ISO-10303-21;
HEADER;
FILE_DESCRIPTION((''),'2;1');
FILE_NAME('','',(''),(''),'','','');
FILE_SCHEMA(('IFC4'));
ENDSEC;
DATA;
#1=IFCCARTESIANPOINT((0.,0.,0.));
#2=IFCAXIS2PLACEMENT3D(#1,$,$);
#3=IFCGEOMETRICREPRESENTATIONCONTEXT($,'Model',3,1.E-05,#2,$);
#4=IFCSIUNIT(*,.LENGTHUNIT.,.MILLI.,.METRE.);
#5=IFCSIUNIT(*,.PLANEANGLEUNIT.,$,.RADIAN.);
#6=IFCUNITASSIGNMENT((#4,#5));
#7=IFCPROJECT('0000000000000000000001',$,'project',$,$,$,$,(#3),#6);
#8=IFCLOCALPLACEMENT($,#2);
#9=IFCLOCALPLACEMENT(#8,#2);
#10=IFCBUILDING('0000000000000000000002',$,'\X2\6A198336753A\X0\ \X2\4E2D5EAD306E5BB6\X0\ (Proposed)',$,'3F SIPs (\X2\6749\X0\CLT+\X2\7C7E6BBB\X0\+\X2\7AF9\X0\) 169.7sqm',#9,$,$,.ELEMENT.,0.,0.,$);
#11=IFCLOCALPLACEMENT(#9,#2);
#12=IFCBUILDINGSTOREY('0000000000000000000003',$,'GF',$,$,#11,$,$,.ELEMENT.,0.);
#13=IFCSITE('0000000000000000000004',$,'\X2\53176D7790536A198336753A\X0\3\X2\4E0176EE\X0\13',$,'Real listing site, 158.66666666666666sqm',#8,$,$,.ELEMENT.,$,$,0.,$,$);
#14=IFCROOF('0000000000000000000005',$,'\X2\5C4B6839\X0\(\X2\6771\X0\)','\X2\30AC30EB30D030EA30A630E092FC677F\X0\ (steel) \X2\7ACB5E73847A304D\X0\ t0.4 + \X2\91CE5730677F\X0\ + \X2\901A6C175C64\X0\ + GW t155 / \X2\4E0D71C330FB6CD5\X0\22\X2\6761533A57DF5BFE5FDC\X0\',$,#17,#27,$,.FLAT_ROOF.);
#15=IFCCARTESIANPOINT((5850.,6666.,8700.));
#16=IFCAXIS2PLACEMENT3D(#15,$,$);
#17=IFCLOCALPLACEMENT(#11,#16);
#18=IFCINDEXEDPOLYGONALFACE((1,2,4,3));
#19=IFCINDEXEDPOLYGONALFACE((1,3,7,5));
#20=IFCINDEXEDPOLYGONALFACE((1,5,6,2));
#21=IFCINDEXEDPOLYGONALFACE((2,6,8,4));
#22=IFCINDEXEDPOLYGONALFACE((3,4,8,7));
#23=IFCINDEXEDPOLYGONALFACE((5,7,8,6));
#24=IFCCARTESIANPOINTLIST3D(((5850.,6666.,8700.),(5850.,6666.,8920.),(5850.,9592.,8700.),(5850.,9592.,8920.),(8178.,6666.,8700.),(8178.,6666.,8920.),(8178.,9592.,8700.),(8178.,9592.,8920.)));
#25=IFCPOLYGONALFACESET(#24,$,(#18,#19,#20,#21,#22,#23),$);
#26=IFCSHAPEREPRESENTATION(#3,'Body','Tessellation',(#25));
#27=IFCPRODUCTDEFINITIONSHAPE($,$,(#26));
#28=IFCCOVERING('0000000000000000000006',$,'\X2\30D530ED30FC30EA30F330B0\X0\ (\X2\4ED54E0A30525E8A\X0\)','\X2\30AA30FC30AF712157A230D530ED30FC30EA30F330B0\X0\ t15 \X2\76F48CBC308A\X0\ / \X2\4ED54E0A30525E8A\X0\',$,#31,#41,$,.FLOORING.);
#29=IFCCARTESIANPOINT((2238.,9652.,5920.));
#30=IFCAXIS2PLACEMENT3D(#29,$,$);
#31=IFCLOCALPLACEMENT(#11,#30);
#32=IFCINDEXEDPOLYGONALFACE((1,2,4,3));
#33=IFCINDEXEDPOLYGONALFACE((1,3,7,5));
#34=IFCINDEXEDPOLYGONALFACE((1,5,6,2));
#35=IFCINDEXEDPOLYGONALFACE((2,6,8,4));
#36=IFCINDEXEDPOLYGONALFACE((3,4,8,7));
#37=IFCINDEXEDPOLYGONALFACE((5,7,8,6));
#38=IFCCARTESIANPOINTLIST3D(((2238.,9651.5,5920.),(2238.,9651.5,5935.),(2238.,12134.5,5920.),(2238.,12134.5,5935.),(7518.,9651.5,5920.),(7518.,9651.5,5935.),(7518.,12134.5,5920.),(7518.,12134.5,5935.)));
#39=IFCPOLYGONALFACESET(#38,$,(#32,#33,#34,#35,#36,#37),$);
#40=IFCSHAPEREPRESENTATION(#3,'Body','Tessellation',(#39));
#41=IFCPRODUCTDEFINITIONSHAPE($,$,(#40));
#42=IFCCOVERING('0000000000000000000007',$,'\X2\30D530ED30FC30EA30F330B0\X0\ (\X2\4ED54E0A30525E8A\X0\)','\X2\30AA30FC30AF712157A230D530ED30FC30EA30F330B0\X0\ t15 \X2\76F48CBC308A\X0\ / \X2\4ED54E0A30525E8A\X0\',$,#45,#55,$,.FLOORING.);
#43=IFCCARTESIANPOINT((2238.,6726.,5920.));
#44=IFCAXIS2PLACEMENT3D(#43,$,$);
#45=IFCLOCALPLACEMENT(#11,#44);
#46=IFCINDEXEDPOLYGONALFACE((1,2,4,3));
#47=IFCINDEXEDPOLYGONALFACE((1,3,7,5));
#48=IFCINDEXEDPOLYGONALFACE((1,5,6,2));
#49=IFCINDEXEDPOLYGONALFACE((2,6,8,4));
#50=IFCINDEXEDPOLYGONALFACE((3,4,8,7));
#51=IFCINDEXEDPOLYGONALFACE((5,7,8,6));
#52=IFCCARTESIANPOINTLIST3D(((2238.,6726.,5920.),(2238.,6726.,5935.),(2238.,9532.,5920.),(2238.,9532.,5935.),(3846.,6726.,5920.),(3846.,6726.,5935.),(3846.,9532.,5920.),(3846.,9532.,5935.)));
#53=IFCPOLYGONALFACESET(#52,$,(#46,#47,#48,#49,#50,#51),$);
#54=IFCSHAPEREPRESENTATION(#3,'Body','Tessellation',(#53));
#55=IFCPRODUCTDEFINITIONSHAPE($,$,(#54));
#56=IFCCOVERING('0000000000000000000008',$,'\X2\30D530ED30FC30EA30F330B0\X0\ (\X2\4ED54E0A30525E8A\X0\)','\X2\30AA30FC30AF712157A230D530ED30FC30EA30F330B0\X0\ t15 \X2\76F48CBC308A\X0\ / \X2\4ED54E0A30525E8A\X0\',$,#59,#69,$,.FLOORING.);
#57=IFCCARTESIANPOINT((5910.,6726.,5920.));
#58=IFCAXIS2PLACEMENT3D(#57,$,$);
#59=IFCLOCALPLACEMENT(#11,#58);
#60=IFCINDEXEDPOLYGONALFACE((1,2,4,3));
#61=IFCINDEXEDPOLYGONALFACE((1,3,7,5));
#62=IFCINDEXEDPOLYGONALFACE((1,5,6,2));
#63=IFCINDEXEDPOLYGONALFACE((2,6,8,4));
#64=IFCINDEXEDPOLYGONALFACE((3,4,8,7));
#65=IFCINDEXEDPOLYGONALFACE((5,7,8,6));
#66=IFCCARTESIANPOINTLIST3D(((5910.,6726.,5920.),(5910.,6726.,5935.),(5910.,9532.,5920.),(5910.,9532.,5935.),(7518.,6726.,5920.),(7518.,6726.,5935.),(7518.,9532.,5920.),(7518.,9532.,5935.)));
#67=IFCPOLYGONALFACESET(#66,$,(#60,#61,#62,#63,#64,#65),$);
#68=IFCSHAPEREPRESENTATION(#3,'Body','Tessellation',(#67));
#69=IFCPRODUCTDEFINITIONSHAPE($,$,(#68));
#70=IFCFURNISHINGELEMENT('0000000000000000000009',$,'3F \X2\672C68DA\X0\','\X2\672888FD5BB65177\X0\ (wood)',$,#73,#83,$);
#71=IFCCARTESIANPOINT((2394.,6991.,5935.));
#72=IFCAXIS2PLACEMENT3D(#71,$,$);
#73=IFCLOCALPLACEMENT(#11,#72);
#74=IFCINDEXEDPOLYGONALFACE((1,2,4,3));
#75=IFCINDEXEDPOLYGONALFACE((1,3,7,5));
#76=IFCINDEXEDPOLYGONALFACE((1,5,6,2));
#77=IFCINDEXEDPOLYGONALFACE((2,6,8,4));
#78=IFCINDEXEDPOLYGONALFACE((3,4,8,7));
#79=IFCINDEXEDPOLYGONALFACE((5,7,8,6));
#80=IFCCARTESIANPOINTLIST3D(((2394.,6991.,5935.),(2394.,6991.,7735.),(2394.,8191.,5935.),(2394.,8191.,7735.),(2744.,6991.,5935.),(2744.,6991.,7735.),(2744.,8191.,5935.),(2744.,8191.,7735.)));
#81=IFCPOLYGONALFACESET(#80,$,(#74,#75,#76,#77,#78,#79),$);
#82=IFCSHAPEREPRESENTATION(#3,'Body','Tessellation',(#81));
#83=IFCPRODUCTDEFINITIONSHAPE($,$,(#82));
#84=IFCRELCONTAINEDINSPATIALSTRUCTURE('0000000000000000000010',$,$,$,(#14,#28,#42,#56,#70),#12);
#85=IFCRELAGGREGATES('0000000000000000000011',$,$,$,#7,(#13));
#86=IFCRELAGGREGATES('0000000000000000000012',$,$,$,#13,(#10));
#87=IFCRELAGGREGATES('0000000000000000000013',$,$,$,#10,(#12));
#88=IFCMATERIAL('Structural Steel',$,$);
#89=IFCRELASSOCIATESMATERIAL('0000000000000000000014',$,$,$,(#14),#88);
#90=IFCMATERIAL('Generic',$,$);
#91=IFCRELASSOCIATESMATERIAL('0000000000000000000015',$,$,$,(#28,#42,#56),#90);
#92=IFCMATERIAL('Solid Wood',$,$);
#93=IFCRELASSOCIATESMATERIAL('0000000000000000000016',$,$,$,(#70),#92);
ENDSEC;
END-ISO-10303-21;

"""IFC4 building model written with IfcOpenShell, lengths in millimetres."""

from ifc_helpers import new_model, si_unit, frame, frame_2d, origin, place, context, project, spatial, rectangle, extrude, material, element, save


model = new_model("IFC4")

# Units and contexts
model_context = context("Model", 3, precision=1e-05, world=origin())
ifc_project = project(units=[si_unit("LENGTHUNIT", "METRE", prefix="MILLI"), si_unit("PLANEANGLEUNIT", "RADIAN")], contexts=[model_context])

# Site, building, storey
site_placement = place(None, origin())
site = spatial("IfcSite", under=ifc_project, at=site_placement, Name="北海道標茶町3丁目13", ObjectType="Real listing site, 158.66666666666666sqm", CompositionType="ELEMENT", RefElevation=0.0)
building_placement = place(site_placement, origin())
building = spatial("IfcBuilding", under=site, at=building_placement, Name="標茶町 中庭の家 (Proposed)", ObjectType="3F SIPs (杉CLT+籾殻+竹) 169.7sqm", CompositionType="ELEMENT", ElevationOfRefHeight=0.0, ElevationOfTerrain=0.0)
storey_placement = place(building_placement, origin())
storey = spatial("IfcBuildingStorey", under=building, at=storey_placement, Name="GF", CompositionType="ELEMENT", Elevation=0.0)

# Shared definitions
ifc_material_1 = material(Name="Solid Wood")

# Shared definitions
ifc_material_2 = material(Name="Generic")

# Roof
ifc_material_3 = material(Name="Structural Steel")
roof_1_placement = place(storey_placement, frame((5850.0, 6666.0, 8700.0)))
element("IfcRoof", 1, at=roof_1_placement, inside=storey, material=ifc_material_3, Name="屋根(東)", Description="ガルバリウム鋼板 (steel) 立平葺き t0.4 + 野地板 + 通気層 + GW t155 / 不燃・法22条区域対応", PredefinedType="FLAT_ROOF", context=model_context, shape_type="SweptSolid", body=[
    extrude(rectangle(XDim=2328.0, YDim=2926.0, at=frame_2d((1164.0, 1463.0))), frame((5850.0, 6666.0, 8700.0)), (0.0, 0.0, 1.0), 220.0),
])

# Coverings
covering_1_placement = place(storey_placement, frame((2238.0, 9652.0, 5920.0)))
element("IfcCovering", 2, at=covering_1_placement, inside=storey, material=ifc_material_2, Name="フローリング (仕上げ床)", Description="オーク無垢フローリング t15 直貼り / 仕上げ床", PredefinedType="FLOORING", context=model_context, shape_type="SweptSolid", body=[
    extrude(rectangle(XDim=5280.0, YDim=2483.0, at=frame_2d((2640.0, 1241.0))), frame((2238.0, 9652.0, 5920.0)), (0.0, 0.0, 1.0), 15.0),
])
covering_2_placement = place(storey_placement, frame((2238.0, 6726.0, 5920.0)))
element("IfcCovering", 3, at=covering_2_placement, inside=storey, material=ifc_material_2, Name="フローリング (仕上げ床)", Description="オーク無垢フローリング t15 直貼り / 仕上げ床", PredefinedType="FLOORING", context=model_context, shape_type="SweptSolid", body=[
    extrude(rectangle(XDim=1608.0, YDim=2806.0, at=frame_2d((804.0, 1403.0))), frame((2238.0, 6726.0, 5920.0)), (0.0, 0.0, 1.0), 15.0),
])
covering_3_placement = place(storey_placement, frame((5910.0, 6726.0, 5920.0)))
element("IfcCovering", 4, at=covering_3_placement, inside=storey, material=ifc_material_2, Name="フローリング (仕上げ床)", Description="オーク無垢フローリング t15 直貼り / 仕上げ床", PredefinedType="FLOORING", context=model_context, shape_type="SweptSolid", body=[
    extrude(rectangle(XDim=1608.0, YDim=2806.0, at=frame_2d((804.0, 1403.0))), frame((5910.0, 6726.0, 5920.0)), (0.0, 0.0, 1.0), 15.0),
])

# Furnishing element
furnishing_placement = place(storey_placement, frame((2394.0, 6991.0, 5935.0)))
element("IfcFurnishingElement", 5, at=furnishing_placement, inside=storey, material=ifc_material_1, Name="3F 本棚", Description="木製家具 (wood)", context=model_context, shape_type="SweptSolid", body=[
    extrude(rectangle(XDim=350.0, YDim=1200.0, at=frame_2d((175.0, 600.0))), frame((2394.0, 6991.0, 5935.0)), (0.0, 0.0, 1.0), 1800.0),
])

save(model, "model.ifc")
